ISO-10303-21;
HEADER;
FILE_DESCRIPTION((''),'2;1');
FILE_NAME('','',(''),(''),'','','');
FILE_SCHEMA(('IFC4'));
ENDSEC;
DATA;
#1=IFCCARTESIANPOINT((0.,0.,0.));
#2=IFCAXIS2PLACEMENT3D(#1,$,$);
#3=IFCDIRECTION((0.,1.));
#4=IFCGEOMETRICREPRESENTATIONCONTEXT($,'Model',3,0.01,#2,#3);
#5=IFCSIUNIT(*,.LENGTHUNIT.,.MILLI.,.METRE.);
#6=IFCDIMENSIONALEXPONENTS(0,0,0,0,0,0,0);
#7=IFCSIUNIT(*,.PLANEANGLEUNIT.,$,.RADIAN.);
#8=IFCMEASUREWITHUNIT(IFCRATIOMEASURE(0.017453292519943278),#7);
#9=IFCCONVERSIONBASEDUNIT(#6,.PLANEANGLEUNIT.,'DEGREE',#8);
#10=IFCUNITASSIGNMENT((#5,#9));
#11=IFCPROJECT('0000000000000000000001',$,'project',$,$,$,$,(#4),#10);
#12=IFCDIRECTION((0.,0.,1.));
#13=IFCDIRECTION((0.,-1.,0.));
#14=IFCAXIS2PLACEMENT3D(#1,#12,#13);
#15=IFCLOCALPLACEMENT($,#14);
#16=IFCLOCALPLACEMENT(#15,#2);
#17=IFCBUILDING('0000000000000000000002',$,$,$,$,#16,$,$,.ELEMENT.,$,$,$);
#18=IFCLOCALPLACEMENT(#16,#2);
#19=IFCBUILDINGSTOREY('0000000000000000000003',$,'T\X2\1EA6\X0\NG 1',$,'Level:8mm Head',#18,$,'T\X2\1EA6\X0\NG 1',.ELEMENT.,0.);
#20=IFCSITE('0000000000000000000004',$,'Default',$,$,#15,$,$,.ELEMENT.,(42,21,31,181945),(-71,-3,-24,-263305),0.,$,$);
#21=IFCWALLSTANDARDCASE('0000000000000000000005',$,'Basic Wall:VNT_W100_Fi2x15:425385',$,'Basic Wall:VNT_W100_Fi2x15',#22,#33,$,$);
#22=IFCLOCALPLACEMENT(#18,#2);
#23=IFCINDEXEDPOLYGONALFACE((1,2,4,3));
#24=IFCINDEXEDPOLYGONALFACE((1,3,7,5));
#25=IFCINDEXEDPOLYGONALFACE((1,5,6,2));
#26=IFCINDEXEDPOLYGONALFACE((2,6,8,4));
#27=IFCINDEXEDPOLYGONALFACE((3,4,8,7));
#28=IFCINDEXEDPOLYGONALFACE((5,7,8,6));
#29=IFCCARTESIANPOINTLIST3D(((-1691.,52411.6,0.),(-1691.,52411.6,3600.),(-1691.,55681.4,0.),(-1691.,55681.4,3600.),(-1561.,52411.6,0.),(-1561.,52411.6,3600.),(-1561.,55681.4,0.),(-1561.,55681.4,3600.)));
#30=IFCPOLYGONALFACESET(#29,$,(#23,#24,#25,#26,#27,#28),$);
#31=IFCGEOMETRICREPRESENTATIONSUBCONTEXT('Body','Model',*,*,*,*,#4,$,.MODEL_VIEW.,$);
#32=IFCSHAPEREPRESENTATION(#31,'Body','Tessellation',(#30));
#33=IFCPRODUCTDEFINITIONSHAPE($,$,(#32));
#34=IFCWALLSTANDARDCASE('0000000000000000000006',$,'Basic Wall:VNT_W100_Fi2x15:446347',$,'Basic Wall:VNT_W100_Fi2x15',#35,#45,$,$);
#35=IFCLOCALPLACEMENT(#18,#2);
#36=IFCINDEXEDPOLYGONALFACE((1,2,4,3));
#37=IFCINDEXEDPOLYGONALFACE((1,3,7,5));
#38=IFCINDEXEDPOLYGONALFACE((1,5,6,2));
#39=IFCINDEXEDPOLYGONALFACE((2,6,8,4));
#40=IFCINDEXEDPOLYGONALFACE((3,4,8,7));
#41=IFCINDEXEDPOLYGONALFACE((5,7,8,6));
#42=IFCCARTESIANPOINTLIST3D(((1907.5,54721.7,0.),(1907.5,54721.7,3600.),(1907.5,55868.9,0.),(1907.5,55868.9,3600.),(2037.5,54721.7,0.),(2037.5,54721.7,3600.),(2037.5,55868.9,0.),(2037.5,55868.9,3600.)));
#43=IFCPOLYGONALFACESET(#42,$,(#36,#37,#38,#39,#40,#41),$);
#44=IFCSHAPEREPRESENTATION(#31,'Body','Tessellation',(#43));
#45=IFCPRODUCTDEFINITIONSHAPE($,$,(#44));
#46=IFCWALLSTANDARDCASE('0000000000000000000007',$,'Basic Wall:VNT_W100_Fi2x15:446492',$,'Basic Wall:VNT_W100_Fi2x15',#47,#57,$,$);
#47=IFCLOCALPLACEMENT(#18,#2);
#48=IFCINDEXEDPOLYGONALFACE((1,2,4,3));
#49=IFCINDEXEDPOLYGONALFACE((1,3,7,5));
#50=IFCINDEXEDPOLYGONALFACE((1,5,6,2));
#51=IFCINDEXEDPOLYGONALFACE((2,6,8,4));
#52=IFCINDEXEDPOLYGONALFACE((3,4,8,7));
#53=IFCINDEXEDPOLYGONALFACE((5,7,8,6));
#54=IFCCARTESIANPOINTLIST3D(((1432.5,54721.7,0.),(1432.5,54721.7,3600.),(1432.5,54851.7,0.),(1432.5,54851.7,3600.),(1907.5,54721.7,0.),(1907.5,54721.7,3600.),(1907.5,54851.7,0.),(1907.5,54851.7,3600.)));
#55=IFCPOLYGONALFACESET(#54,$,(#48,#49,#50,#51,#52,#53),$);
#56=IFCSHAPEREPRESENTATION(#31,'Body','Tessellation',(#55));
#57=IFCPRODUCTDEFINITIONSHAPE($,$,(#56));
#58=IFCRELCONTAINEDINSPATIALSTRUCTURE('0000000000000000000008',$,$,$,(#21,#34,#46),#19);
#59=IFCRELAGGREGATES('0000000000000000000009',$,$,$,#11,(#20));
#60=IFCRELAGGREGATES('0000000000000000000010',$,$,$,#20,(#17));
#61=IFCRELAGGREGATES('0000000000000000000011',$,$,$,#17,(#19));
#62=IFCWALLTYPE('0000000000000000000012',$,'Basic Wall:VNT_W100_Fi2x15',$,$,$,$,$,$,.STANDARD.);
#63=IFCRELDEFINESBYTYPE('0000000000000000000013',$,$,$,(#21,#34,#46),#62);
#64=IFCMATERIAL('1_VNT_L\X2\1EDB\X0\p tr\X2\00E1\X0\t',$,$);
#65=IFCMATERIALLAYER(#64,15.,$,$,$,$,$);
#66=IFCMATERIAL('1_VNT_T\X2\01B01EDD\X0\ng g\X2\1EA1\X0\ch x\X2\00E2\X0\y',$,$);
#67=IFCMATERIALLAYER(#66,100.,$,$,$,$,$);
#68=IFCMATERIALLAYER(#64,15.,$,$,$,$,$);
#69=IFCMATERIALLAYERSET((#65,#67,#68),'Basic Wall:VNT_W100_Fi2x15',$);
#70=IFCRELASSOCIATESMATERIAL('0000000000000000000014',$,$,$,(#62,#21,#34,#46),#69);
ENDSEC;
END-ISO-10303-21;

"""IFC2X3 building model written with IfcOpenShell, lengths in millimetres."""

from ifc_helpers import new_model, entity, si_unit, converted_unit, direction, frame, frame_2d, origin, place, context, subcontext, project, spatial, rectangle, extrude, material, layer, layer_set, layer_usage, type_object, element, save


model = new_model("IFC2X3")

# Units and contexts
model_context = context("Model", 3, precision=0.01, world=origin(), true_north=direction((0.0, 1.0)))
body_context = subcontext(model_context, "Body", "Model", "MODEL_VIEW")
ifc_project = project(units=[si_unit("LENGTHUNIT", "METRE", prefix="MILLI"), converted_unit("PLANEANGLEUNIT", "DEGREE", entity("IfcRatioMeasure", 0.017453292519943278), si_unit("PLANEANGLEUNIT", "RADIAN"), dimensions=[0, 0, 0, 0, 0, 0, 0])], contexts=[model_context])

# Site, building, storey
site_placement = place(None, frame((0.0, 0.0, 0.0), z_axis=(0.0, 0.0, 1.0), x_axis=(0.0, -1.0, 0.0)))
site = spatial("IfcSite", under=ifc_project, at=site_placement, Name="Default", CompositionType="ELEMENT", RefLatitude=(42, 21, 31, 181945), RefLongitude=(-71, -3, -24, -263305), RefElevation=0.0)
building_placement = place(site_placement, origin())
building = spatial("IfcBuilding", under=site, at=building_placement, CompositionType="ELEMENT")
storey_placement = place(building_placement, origin())
storey = spatial("IfcBuildingStorey", under=building, at=storey_placement, Name="TẦNG 1", ObjectType="Level:8mm Head", LongName="TẦNG 1", CompositionType="ELEMENT", Elevation=0.0)

# Shared definitions
ifc_material_1 = material(Name="1_VNT_Lớp trát")
ifc_material_2 = material(Name="1_VNT_Tường gạch xây")

# Walls
ifc_layer_1 = layer(ifc_material_1, 15.0)
ifc_layer_2 = layer(ifc_material_2, 100.0)
ifc_layer_3 = layer(ifc_material_1, 15.0)
ifc_layer_set_1 = layer_set([ifc_layer_1, ifc_layer_2, ifc_layer_3], Name="Basic Wall:VNT_W100_Fi2x15")
ifc_layer_usage_1 = layer_usage(ifc_layer_set_1, "AXIS2", "NEGATIVE", 65.0)
wall_type_1 = type_object("IfcWallType", Name="Basic Wall:VNT_W100_Fi2x15", PredefinedType="STANDARD", material=ifc_layer_set_1)
wall_1_placement = place(storey_placement, frame((-1626.0, 52411.6, 0.0), z_axis=(0.0, 0.0, 1.0), x_axis=(0.0, 1.0, 0.0)))
element("IfcWallStandardCase", 1, at=wall_1_placement, inside=storey, type_object=wall_type_1, material=ifc_layer_usage_1, Name="Basic Wall:VNT_W100_Fi2x15:425385", ObjectType="Basic Wall:VNT_W100_Fi2x15", context=body_context, shape_type="SweptSolid", body=[
    extrude(rectangle(XDim=3269.8, YDim=130.0, at=frame_2d((1634.9, 0.0), x_axis=(-1.0, 0.0))), origin(), (0.0, 0.0, 1.0), 3600.0),
])
wall_2_placement = place(storey_placement, frame((1972.5, 55868.9, 0.0), z_axis=(0.0, 0.0, 1.0), x_axis=(0.0, -1.0, 0.0)))
element("IfcWallStandardCase", 2, at=wall_2_placement, inside=storey, type_object=wall_type_1, material=ifc_layer_usage_1, Name="Basic Wall:VNT_W100_Fi2x15:446347", ObjectType="Basic Wall:VNT_W100_Fi2x15", context=body_context, shape_type="SweptSolid", body=[
    extrude(rectangle(XDim=1147.1, YDim=130.0, at=frame_2d((573.6, 0.0), x_axis=(-1.0, 0.0))), origin(), (0.0, 0.0, 1.0), 3600.0),
])
wall_3_placement = place(storey_placement, frame((1907.5, 54786.7, 0.0), z_axis=(0.0, 0.0, 1.0), x_axis=(-1.0, 0.0, 0.0)))
element("IfcWallStandardCase", 3, at=wall_3_placement, inside=storey, type_object=wall_type_1, material=ifc_layer_usage_1, Name="Basic Wall:VNT_W100_Fi2x15:446492", ObjectType="Basic Wall:VNT_W100_Fi2x15", context=body_context, shape_type="SweptSolid", body=[
    extrude(rectangle(XDim=475.0, YDim=130.0, at=frame_2d((237.5, 0.0), x_axis=(-1.0, 0.0))), origin(), (0.0, 0.0, 1.0), 3600.0),
])

save(model, "model.ifc")
